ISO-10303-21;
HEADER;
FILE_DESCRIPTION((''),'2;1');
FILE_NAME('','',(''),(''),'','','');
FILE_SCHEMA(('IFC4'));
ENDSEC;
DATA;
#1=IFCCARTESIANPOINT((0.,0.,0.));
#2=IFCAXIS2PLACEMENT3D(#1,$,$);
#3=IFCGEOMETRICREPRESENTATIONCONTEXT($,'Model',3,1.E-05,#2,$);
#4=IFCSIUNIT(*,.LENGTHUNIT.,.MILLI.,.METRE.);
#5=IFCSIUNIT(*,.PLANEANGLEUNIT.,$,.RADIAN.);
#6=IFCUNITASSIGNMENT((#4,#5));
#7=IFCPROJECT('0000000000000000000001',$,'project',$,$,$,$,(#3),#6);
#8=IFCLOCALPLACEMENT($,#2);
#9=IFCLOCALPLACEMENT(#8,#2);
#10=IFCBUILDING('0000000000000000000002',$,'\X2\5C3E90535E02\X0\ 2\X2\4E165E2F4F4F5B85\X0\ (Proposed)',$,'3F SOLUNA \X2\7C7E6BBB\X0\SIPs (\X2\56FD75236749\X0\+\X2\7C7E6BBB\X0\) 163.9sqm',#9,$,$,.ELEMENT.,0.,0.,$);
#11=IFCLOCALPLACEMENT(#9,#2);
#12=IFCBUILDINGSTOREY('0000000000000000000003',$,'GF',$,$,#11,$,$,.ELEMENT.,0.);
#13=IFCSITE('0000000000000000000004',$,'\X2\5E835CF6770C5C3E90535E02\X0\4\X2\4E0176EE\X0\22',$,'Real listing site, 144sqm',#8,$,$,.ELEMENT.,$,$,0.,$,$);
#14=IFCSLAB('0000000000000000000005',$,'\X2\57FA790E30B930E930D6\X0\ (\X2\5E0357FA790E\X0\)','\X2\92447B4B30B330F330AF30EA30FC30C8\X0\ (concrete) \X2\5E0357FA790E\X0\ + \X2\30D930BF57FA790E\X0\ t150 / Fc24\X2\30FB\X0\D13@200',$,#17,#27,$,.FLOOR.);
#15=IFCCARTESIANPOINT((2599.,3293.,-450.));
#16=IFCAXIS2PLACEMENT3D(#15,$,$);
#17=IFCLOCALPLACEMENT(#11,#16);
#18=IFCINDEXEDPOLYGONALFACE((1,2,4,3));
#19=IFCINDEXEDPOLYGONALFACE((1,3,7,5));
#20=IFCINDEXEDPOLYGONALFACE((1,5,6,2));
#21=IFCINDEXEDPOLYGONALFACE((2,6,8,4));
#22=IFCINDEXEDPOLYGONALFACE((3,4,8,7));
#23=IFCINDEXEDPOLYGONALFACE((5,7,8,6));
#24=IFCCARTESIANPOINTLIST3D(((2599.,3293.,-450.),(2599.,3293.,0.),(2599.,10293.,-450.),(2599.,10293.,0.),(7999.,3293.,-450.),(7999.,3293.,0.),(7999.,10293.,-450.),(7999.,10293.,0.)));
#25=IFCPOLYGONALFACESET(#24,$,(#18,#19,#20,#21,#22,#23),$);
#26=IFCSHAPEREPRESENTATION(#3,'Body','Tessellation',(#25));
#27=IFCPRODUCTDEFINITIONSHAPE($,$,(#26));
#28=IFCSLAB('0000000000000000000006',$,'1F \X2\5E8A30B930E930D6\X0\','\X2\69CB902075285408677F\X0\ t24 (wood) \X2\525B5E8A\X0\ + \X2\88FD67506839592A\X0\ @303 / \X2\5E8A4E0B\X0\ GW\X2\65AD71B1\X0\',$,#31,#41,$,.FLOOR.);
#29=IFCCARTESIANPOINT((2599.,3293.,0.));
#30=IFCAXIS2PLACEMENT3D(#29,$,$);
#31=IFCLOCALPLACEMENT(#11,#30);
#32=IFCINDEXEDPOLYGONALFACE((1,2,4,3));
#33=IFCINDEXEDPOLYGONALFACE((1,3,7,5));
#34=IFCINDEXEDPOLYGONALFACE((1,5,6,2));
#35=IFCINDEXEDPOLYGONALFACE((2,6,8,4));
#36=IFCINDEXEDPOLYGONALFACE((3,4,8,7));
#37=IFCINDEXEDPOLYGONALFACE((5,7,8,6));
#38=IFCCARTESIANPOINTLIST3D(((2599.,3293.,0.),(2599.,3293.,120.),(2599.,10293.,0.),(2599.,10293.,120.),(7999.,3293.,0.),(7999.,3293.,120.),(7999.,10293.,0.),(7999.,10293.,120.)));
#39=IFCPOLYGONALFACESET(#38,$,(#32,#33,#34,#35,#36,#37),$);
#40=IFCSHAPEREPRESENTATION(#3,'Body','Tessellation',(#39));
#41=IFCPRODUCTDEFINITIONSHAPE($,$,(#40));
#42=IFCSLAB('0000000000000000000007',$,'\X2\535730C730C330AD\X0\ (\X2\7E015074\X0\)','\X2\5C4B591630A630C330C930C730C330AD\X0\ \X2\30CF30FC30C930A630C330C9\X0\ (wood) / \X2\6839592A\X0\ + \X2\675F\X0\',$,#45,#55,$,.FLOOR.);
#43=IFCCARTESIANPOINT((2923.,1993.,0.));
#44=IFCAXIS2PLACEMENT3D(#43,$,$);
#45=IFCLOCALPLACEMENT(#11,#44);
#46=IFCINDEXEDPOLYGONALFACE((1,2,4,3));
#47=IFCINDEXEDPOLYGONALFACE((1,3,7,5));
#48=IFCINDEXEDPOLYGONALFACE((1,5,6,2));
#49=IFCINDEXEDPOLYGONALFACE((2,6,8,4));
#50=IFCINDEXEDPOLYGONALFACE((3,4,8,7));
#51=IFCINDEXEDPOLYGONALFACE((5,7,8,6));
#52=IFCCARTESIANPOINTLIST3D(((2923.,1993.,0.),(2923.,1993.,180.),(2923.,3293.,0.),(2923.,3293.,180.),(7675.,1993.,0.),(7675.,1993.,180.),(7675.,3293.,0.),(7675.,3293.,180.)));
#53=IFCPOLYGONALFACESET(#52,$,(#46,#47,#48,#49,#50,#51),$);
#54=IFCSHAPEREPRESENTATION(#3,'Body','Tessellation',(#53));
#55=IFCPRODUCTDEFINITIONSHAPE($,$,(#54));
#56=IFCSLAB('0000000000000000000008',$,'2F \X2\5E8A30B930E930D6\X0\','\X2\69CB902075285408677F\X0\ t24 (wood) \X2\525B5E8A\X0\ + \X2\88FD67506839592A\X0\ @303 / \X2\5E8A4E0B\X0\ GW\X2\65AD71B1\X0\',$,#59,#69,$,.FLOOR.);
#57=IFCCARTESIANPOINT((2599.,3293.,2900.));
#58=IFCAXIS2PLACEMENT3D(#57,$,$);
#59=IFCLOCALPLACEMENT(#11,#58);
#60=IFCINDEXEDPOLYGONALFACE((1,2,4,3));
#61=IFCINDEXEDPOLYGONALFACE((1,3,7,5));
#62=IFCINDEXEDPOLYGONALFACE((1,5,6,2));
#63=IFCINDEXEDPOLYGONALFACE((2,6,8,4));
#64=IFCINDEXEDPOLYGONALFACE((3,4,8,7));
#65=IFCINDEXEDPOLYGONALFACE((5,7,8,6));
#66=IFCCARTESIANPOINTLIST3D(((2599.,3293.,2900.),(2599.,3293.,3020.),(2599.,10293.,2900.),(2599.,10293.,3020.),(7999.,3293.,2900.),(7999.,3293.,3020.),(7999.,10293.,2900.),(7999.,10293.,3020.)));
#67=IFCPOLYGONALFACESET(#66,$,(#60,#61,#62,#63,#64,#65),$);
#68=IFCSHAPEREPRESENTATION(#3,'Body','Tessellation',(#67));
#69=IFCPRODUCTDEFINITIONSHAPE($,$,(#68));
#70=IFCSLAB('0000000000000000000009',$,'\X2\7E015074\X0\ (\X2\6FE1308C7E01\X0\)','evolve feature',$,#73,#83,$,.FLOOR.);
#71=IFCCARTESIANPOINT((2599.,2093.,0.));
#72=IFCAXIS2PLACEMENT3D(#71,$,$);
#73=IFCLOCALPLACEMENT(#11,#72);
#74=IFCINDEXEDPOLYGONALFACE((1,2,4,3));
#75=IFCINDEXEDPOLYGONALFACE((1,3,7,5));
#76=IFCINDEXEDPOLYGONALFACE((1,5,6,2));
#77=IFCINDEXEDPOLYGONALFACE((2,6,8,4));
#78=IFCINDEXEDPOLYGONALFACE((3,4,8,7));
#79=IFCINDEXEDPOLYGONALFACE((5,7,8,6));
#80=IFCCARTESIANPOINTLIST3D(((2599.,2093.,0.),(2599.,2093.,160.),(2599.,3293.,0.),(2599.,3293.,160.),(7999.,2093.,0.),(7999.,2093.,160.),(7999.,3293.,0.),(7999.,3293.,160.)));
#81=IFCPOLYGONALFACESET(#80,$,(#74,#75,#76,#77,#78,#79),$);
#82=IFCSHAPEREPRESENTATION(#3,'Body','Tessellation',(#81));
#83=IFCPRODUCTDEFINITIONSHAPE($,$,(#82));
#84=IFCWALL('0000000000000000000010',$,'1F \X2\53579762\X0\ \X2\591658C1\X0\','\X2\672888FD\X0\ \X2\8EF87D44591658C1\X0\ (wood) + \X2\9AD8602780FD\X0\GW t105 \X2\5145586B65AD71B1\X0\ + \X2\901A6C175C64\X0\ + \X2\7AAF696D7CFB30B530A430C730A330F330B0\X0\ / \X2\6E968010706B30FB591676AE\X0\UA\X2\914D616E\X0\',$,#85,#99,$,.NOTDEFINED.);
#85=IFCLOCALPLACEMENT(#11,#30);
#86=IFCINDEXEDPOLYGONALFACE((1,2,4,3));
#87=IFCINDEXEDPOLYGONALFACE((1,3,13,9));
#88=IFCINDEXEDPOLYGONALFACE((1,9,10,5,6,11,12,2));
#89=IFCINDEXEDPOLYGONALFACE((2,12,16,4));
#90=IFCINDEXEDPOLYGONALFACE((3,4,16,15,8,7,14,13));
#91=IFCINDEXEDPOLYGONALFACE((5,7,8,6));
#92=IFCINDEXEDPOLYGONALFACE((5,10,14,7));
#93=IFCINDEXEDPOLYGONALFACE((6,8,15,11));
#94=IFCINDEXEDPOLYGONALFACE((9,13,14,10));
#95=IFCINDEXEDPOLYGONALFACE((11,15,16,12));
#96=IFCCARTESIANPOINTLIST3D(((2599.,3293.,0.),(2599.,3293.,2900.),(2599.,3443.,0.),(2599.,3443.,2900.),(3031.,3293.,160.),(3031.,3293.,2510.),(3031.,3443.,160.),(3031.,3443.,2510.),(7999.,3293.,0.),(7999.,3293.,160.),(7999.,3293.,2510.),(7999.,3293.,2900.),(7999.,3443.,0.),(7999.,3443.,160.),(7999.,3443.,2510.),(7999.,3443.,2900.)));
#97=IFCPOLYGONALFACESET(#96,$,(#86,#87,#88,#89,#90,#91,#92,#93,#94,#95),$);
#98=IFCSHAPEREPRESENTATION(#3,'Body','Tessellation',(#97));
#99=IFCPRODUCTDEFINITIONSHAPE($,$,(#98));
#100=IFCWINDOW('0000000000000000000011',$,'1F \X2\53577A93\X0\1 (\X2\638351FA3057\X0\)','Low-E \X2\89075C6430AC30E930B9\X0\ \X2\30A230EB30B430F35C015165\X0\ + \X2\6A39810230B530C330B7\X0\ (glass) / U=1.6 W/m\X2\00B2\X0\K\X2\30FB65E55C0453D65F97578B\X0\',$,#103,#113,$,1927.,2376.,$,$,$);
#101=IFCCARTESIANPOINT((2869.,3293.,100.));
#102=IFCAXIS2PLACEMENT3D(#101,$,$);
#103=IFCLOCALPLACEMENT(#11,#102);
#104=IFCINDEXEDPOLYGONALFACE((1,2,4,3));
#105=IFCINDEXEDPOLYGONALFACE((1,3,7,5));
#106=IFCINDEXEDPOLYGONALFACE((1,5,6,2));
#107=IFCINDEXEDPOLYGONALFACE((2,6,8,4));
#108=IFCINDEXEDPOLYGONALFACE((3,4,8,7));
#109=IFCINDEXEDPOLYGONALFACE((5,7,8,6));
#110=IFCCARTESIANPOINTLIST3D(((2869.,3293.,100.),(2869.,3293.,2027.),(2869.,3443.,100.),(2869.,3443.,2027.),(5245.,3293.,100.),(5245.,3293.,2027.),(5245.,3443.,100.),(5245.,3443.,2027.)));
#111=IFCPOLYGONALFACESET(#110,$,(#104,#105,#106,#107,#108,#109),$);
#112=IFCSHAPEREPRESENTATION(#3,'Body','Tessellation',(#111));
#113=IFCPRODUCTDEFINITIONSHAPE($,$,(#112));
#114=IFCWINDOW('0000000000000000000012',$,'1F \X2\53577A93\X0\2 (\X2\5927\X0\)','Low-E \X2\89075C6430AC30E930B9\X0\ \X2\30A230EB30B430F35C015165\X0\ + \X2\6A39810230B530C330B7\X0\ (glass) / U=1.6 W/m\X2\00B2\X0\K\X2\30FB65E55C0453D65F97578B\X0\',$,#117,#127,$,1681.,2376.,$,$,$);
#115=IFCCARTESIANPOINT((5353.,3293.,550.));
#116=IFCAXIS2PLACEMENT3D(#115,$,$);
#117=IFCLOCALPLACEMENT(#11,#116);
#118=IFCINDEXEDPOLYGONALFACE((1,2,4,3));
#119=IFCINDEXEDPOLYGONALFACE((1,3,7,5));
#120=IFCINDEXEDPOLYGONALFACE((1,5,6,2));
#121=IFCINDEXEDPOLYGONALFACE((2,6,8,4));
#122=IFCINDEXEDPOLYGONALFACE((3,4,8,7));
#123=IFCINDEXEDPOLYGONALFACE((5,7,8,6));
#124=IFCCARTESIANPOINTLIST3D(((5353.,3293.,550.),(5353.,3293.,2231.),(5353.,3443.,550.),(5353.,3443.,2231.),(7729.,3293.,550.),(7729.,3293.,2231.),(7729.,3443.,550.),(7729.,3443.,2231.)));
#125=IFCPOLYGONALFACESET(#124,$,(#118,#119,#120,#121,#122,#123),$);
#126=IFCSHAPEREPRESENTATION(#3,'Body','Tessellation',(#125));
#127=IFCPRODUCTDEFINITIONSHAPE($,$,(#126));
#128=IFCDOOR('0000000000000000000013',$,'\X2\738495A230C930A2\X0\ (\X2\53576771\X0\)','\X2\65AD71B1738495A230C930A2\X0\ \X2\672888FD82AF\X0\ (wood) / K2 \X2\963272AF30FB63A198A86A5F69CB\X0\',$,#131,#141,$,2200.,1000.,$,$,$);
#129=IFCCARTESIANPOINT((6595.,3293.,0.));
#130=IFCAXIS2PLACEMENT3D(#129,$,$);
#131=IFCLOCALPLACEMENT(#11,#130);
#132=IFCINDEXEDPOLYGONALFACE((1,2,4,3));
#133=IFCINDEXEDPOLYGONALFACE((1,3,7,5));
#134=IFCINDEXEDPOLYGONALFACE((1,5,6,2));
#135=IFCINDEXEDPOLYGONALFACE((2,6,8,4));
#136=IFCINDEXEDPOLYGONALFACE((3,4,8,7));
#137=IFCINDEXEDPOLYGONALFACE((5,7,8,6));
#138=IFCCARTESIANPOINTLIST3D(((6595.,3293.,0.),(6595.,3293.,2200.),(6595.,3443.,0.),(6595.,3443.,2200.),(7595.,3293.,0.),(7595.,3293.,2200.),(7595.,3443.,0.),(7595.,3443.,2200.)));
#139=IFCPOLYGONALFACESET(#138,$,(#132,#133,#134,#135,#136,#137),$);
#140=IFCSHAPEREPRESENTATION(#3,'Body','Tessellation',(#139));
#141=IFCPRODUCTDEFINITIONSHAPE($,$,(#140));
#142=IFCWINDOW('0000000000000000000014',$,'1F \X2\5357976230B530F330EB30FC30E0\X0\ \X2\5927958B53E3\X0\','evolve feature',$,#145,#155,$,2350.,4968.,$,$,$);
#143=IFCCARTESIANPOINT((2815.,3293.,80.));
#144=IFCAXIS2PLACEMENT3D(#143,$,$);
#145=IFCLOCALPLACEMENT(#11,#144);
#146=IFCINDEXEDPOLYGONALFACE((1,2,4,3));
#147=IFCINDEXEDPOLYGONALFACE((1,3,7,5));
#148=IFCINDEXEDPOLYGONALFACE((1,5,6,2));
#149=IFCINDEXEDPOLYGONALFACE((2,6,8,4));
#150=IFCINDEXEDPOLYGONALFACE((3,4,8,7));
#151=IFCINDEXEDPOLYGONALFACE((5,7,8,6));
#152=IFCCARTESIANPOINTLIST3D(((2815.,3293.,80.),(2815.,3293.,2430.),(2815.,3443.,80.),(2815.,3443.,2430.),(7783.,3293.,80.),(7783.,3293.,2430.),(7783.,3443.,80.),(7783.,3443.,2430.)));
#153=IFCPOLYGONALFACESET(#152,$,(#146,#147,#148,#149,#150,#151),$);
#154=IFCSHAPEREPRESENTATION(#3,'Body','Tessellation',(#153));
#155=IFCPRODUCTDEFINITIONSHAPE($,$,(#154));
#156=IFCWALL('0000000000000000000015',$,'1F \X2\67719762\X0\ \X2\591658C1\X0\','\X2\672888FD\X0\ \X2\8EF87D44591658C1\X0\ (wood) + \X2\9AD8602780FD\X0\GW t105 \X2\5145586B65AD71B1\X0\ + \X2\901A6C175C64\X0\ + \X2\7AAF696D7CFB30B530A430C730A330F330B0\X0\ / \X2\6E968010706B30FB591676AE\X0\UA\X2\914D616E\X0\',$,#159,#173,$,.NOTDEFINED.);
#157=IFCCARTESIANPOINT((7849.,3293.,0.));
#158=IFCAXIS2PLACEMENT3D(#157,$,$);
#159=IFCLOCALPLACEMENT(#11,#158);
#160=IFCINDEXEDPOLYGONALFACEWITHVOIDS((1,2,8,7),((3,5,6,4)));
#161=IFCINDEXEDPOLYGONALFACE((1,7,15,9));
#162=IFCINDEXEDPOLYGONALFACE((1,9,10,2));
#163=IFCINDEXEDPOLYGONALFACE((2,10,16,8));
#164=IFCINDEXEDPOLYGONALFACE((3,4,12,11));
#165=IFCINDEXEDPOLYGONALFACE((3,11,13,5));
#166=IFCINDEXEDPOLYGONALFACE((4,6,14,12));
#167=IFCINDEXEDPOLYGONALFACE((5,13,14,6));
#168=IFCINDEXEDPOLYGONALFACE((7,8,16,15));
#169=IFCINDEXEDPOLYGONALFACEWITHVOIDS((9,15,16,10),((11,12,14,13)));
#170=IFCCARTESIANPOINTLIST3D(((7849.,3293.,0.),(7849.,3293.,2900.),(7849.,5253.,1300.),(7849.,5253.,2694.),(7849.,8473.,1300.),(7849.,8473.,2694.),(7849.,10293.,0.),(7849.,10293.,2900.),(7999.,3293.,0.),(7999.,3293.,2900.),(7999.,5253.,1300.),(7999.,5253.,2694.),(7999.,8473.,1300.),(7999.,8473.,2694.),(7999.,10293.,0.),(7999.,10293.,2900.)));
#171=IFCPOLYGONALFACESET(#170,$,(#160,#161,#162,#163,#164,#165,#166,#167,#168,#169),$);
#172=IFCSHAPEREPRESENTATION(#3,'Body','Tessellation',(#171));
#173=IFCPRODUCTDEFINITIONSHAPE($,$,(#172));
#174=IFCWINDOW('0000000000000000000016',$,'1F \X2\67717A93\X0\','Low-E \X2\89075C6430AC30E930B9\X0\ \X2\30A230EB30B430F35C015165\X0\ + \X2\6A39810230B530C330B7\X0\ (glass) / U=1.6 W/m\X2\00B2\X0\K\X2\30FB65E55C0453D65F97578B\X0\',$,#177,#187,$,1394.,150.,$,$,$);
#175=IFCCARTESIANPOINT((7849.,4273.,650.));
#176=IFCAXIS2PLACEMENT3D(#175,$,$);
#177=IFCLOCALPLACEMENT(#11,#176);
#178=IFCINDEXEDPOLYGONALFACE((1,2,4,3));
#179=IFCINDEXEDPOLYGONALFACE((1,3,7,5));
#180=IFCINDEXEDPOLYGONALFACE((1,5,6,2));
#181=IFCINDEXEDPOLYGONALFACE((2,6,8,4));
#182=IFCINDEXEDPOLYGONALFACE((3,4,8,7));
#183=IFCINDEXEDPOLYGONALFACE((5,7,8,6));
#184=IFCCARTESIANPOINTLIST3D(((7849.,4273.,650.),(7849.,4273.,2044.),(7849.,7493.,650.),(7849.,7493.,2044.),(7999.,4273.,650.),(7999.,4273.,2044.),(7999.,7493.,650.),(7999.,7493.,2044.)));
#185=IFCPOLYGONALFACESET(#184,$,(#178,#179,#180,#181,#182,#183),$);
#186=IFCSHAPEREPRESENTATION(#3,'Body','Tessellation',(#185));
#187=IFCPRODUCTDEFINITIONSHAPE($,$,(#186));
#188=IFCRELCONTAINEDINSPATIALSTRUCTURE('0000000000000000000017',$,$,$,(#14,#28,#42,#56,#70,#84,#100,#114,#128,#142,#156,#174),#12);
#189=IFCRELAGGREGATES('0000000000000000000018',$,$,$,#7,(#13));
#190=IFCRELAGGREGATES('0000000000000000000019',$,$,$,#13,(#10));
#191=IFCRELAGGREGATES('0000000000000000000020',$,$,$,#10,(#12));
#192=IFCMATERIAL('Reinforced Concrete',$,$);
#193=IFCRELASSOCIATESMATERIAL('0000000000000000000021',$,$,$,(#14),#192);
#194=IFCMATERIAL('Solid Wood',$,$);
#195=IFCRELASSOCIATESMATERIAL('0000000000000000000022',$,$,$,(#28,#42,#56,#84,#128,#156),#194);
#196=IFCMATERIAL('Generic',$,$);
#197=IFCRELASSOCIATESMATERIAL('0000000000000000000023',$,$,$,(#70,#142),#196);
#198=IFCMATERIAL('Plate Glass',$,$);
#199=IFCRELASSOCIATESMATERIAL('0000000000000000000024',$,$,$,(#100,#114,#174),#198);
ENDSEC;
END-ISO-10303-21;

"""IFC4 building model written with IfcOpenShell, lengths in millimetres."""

from ifc_helpers import new_model, si_unit, frame, frame_2d, origin, place, context, project, spatial, rectangle, extrude, material, element, fill, save


model = new_model("IFC4")

# Units and contexts
model_context = context("Model", 3, precision=1e-05, world=origin())
ifc_project = project(units=[si_unit("LENGTHUNIT", "METRE", prefix="MILLI"), si_unit("PLANEANGLEUNIT", "RADIAN")], contexts=[model_context])

# Site, building, storey
site_placement = place(None, origin())
site = spatial("IfcSite", under=ifc_project, at=site_placement, Name="広島県尾道市4丁目22", ObjectType="Real listing site, 144sqm", CompositionType="ELEMENT", RefElevation=0.0)
building_placement = place(site_placement, origin())
building = spatial("IfcBuilding", under=site, at=building_placement, Name="尾道市 2世帯住宅 (Proposed)", ObjectType="3F SOLUNA 籾殻SIPs (国産杉+籾殻) 163.9sqm", CompositionType="ELEMENT", ElevationOfRefHeight=0.0, ElevationOfTerrain=0.0)
storey_placement = place(building_placement, origin())
storey = spatial("IfcBuildingStorey", under=building, at=storey_placement, Name="GF", CompositionType="ELEMENT", Elevation=0.0)

# Slabs
ifc_material_1 = material(Name="Reinforced Concrete")
slab_1_placement = place(storey_placement, frame((2599.0, 3293.0, -450.0)))
element("IfcSlab", 1, at=slab_1_placement, inside=storey, material=ifc_material_1, Name="基礎スラブ (布基礎)", Description="鉄筋コンクリート (concrete) 布基礎 + ベタ基礎 t150 / Fc24・D13@200", PredefinedType="FLOOR", context=model_context, shape_type="SweptSolid", body=[
    extrude(rectangle(XDim=5400.0, YDim=7000.0, at=frame_2d((2700.0, 3500.0))), frame((2599.0, 3293.0, -450.0)), (0.0, 0.0, 1.0), 450.0),
])
ifc_material_2 = material(Name="Solid Wood")
slab_2_placement = place(storey_placement, frame((2599.0, 3293.0, 0.0)))
element("IfcSlab", 2, at=slab_2_placement, inside=storey, material=ifc_material_2, Name="1F 床スラブ", Description="構造用合板 t24 (wood) 剛床 + 製材根太 @303 / 床下 GW断熱", PredefinedType="FLOOR", context=model_context, shape_type="SweptSolid", body=[
    extrude(rectangle(XDim=5400.0, YDim=7000.0, at=frame_2d((2700.0, 3500.0))), frame((2599.0, 3293.0, 0.0)), (0.0, 0.0, 1.0), 120.0),
])
slab_3_placement = place(storey_placement, frame((2923.0, 1993.0, 0.0)))
element("IfcSlab", 3, at=slab_3_placement, inside=storey, material=ifc_material_2, Name="南デッキ (縁側)", Description="屋外ウッドデッキ ハードウッド (wood) / 根太 + 束", PredefinedType="FLOOR", context=model_context, shape_type="SweptSolid", body=[
    extrude(rectangle(XDim=4752.0, YDim=1300.0, at=frame_2d((2376.0, 650.0))), frame((2923.0, 1993.0, 0.0)), (0.0, 0.0, 1.0), 180.0),
])
slab_4_placement = place(storey_placement, frame((2599.0, 3293.0, 2900.0)))
element("IfcSlab", 4, at=slab_4_placement, inside=storey, material=ifc_material_2, Name="2F 床スラブ", Description="構造用合板 t24 (wood) 剛床 + 製材根太 @303 / 床下 GW断熱", PredefinedType="FLOOR", context=model_context, shape_type="SweptSolid", body=[
    extrude(rectangle(XDim=5400.0, YDim=7000.0, at=frame_2d((2700.0, 3500.0))), frame((2599.0, 3293.0, 2900.0)), (0.0, 0.0, 1.0), 120.0),
])
ifc_material_3 = material(Name="Generic")
slab_5_placement = place(storey_placement, frame((2599.0, 2093.0, 0.0)))
element("IfcSlab", 5, at=slab_5_placement, inside=storey, material=ifc_material_3, Name="縁側 (濡れ縁)", Description="evolve feature", PredefinedType="FLOOR", context=model_context, shape_type="SweptSolid", body=[
    extrude(rectangle(XDim=5400.0, YDim=1200.0, at=frame_2d((2700.0, 600.0))), frame((2599.0, 2093.0, 0.0)), (0.0, 0.0, 1.0), 160.0),
])

# Wall, openings, windows, door
wall_1_placement = place(storey_placement, frame((2599.0, 3293.0, 0.0)))
wall_1 = element("IfcWall", 6, at=wall_1_placement, inside=storey, material=ifc_material_2, Name="1F 南面 外壁", Description="木製 軸組外壁 (wood) + 高性能GW t105 充填断熱 + 通気層 + 窯業系サイディング / 準耐火・外皮UA配慮", PredefinedType="NOTDEFINED", context=model_context, shape_type="SweptSolid", body=[
    extrude(rectangle(XDim=5400.0, YDim=150.0, at=frame_2d((2700.0, 75.0))), frame((2599.0, 3293.0, 0.0)), (0.0, 0.0, 1.0), 2900.0),
])
opening_1_placement = place(storey_placement, frame((2869.0, 3293.0, 100.0)))
opening_1 = element("IfcOpeningElement", 7, at=opening_1_placement, cuts=wall_1, PredefinedType="NOTDEFINED", context=model_context, shape_type="SweptSolid", body=[
    extrude(rectangle(XDim=2376.0, YDim=150.0, at=frame_2d((1188.0, 75.0))), frame((2869.0, 3293.0, 100.0)), (0.0, 0.0, 1.0), 1927.0),
])
opening_2_placement = place(storey_placement, frame((5353.0, 3293.0, 550.0)))
opening_2 = element("IfcOpeningElement", 8, at=opening_2_placement, cuts=wall_1, PredefinedType="NOTDEFINED", context=model_context, shape_type="SweptSolid", body=[
    extrude(rectangle(XDim=2376.0, YDim=150.0, at=frame_2d((1188.0, 75.0))), frame((5353.0, 3293.0, 550.0)), (0.0, 0.0, 1.0), 1681.0),
])
opening_3_placement = place(storey_placement, frame((6595.0, 3293.0, 0.0)))
opening_3 = element("IfcOpeningElement", 9, at=opening_3_placement, cuts=wall_1, PredefinedType="NOTDEFINED", context=model_context, shape_type="SweptSolid", body=[
    extrude(rectangle(XDim=1000.0, YDim=150.0, at=frame_2d((500.0, 75.0))), frame((6595.0, 3293.0, 0.0)), (0.0, 0.0, 1.0), 2200.0),
])
opening_4_placement = place(storey_placement, frame((2815.0, 3293.0, 80.0)))
opening_4 = element("IfcOpeningElement", 10, at=opening_4_placement, cuts=wall_1, PredefinedType="NOTDEFINED", context=model_context, shape_type="SweptSolid", body=[
    extrude(rectangle(XDim=4968.0, YDim=150.0, at=frame_2d((2484.0, 75.0))), frame((2815.0, 3293.0, 80.0)), (0.0, 0.0, 1.0), 2350.0),
])
ifc_material_4 = material(Name="Plate Glass")
window_1_placement = place(storey_placement, frame((2869.0, 3293.0, 100.0)))
window_1 = element("IfcWindow", 11, at=window_1_placement, inside=storey, material=ifc_material_4, Name="1F 南窓1 (掃出し)", Description="Low-E 複層ガラス アルゴン封入 + 樹脂サッシ (glass) / U=1.6 W/m²K・日射取得型", OverallHeight=1927.0, OverallWidth=2376.0, context=model_context, shape_type="SweptSolid", body=[
    extrude(rectangle(XDim=2376.0, YDim=150.0, at=frame_2d((1188.0, 75.0))), frame((2869.0, 3293.0, 100.0)), (0.0, 0.0, 1.0), 1927.0),
])
fill(opening_1, window_1)
window_2_placement = place(storey_placement, frame((5353.0, 3293.0, 550.0)))
window_2 = element("IfcWindow", 12, at=window_2_placement, inside=storey, material=ifc_material_4, Name="1F 南窓2 (大)", Description="Low-E 複層ガラス アルゴン封入 + 樹脂サッシ (glass) / U=1.6 W/m²K・日射取得型", OverallHeight=1681.0, OverallWidth=2376.0, context=model_context, shape_type="SweptSolid", body=[
    extrude(rectangle(XDim=2376.0, YDim=150.0, at=frame_2d((1188.0, 75.0))), frame((5353.0, 3293.0, 550.0)), (0.0, 0.0, 1.0), 1681.0),
])
fill(opening_2, window_2)
door_placement = place(storey_placement, frame((6595.0, 3293.0, 0.0)))
door = element("IfcDoor", 13, at=door_placement, inside=storey, material=ifc_material_2, Name="玄関ドア (南東)", Description="断熱玄関ドア 木製芯 (wood) / K2 防犯・採風機構", OverallHeight=2200.0, OverallWidth=1000.0, context=model_context, shape_type="SweptSolid", body=[
    extrude(rectangle(XDim=1000.0, YDim=150.0, at=frame_2d((500.0, 75.0))), frame((6595.0, 3293.0, 0.0)), (0.0, 0.0, 1.0), 2200.0),
])
fill(opening_3, door)
window_3_placement = place(storey_placement, frame((2815.0, 3293.0, 80.0)))
window_3 = element("IfcWindow", 14, at=window_3_placement, inside=storey, material=ifc_material_3, Name="1F 南面サンルーム 大開口", Description="evolve feature", OverallHeight=2350.0, OverallWidth=4968.0, context=model_context, shape_type="SweptSolid", body=[
    extrude(rectangle(XDim=4968.0, YDim=150.0, at=frame_2d((2484.0, 75.0))), frame((2815.0, 3293.0, 80.0)), (0.0, 0.0, 1.0), 2350.0),
])
fill(opening_4, window_3)

# Wall, opening, window
wall_2_placement = place(storey_placement, frame((7849.0, 3293.0, 0.0)))
wall_2 = element("IfcWall", 15, at=wall_2_placement, inside=storey, material=ifc_material_2, Name="1F 東面 外壁", Description="木製 軸組外壁 (wood) + 高性能GW t105 充填断熱 + 通気層 + 窯業系サイディング / 準耐火・外皮UA配慮", PredefinedType="NOTDEFINED", context=model_context, shape_type="SweptSolid", body=[
    extrude(rectangle(XDim=150.0, YDim=7000.0, at=frame_2d((75.0, 3500.0))), frame((7849.0, 3293.0, 0.0)), (0.0, 0.0, 1.0), 2900.0),
])
opening_5_placement = place(storey_placement, frame((7849.0, 4273.0, 650.0)))
opening_5 = element("IfcOpeningElement", 16, at=opening_5_placement, cuts=wall_2, PredefinedType="NOTDEFINED", context=model_context, shape_type="SweptSolid", body=[
    extrude(rectangle(XDim=150.0, YDim=3220.0, at=frame_2d((75.0, 1610.0))), frame((7849.0, 4273.0, 650.0)), (0.0, 0.0, 1.0), 1394.0),
])
window_4_placement = place(storey_placement, frame((7849.0, 4273.0, 650.0)))
window_4 = element("IfcWindow", 17, at=window_4_placement, inside=storey, material=ifc_material_4, Name="1F 東窓", Description="Low-E 複層ガラス アルゴン封入 + 樹脂サッシ (glass) / U=1.6 W/m²K・日射取得型", OverallHeight=1394.0, OverallWidth=150.0, context=model_context, shape_type="SweptSolid", body=[
    extrude(rectangle(XDim=150.0, YDim=3220.0, at=frame_2d((75.0, 1610.0))), frame((7849.0, 4273.0, 650.0)), (0.0, 0.0, 1.0), 1394.0),
])
fill(opening_5, window_4)

save(model, "model.ifc")
